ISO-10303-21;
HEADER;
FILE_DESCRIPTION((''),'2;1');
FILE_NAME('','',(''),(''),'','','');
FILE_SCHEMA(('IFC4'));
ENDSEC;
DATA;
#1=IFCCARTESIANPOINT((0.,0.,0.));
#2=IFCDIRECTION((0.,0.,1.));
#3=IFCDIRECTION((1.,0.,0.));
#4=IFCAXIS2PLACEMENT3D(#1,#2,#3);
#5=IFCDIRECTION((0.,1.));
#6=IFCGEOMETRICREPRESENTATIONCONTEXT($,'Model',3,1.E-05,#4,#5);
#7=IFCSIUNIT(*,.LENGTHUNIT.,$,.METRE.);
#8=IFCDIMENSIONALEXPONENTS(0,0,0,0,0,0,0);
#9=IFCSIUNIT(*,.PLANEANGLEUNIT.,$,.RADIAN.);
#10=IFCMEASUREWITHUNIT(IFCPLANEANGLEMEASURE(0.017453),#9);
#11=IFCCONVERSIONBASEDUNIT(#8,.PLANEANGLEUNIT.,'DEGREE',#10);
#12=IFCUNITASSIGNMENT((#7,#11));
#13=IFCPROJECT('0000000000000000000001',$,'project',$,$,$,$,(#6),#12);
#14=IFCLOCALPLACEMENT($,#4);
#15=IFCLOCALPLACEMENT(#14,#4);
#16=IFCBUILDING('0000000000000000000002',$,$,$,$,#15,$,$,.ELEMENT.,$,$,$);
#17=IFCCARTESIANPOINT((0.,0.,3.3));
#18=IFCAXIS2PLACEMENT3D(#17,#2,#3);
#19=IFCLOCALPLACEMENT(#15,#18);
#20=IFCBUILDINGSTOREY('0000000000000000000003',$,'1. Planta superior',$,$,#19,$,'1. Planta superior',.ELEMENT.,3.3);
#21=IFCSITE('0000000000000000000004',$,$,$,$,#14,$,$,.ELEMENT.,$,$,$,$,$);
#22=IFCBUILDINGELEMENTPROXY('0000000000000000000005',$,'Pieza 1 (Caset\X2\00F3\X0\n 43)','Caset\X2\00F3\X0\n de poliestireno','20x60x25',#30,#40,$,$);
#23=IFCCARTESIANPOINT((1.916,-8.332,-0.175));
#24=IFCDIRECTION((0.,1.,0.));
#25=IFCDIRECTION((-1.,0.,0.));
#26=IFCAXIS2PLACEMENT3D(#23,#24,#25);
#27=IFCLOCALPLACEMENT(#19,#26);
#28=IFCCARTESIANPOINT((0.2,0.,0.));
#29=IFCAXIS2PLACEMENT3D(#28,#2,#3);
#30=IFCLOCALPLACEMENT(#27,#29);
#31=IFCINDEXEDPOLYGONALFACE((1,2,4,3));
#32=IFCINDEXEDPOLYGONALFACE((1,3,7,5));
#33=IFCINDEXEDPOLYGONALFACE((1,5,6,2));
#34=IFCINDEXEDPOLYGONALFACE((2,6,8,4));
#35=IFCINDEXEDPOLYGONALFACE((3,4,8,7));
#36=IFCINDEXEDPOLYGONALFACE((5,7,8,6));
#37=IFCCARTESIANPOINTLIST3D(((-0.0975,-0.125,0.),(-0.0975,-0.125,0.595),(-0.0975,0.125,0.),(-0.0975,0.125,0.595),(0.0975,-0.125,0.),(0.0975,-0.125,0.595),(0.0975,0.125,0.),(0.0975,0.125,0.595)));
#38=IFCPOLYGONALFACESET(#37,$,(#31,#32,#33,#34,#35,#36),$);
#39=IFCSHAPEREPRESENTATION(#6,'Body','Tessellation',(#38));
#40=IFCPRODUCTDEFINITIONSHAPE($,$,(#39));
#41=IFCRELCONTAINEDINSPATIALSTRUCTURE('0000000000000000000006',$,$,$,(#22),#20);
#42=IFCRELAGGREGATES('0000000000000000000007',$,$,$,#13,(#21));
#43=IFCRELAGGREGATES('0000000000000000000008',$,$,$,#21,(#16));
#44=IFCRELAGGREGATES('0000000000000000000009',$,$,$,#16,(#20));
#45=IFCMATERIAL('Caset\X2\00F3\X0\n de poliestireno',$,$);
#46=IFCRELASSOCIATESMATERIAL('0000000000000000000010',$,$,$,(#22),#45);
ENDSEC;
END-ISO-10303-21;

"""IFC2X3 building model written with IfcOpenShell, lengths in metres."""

from ifc_helpers import new_model, entity, si_unit, converted_unit, direction, frame, origin_with_axes, origin_2d_with_axis, place, context, project, spatial, rectangle, extrude, source, transform, mapped, material, element, save


model = new_model("IFC2X3")

# Units and contexts
model_context = context("Model", 3, precision=1e-05, world=origin_with_axes(), true_north=direction((0.0, 1.0)))
ifc_project = project(units=[si_unit("LENGTHUNIT", "METRE"), converted_unit("PLANEANGLEUNIT", "DEGREE", entity("IfcPlaneAngleMeasure", 0.017453), si_unit("PLANEANGLEUNIT", "RADIAN"), dimensions=[0, 0, 0, 0, 0, 0, 0])], contexts=[model_context])

# Site, building, storey
site_placement = place(None, origin_with_axes())
site = spatial("IfcSite", under=ifc_project, at=site_placement, CompositionType="ELEMENT")
building_placement = place(site_placement, origin_with_axes())
building = spatial("IfcBuilding", under=site, at=building_placement, CompositionType="ELEMENT")
storey_placement = place(building_placement, frame((0.0, 0.0, 3.3), z_axis=(0.0, 0.0, 1.0), x_axis=(1.0, 0.0, 0.0)))
storey = spatial("IfcBuildingStorey", under=building, at=storey_placement, Name="1. Planta superior", LongName="1. Planta superior", CompositionType="ELEMENT", Elevation=3.3)

# Building element proxy
ifc_material = material(Name="Casetón de poliestireno")
shared_shape = source(origin_with_axes(), model_context, "Body", "SweptSolid", [
    extrude(rectangle(XDim=0.195, YDim=0.25, at=origin_2d_with_axis()), origin_with_axes(), (0.0, 0.0, 1.0), 0.595),
])
placement_1 = place(storey_placement, frame((1.916, -8.332, -0.175), z_axis=(0.0, 1.0, 0.0), x_axis=(-1.0, 0.0, 0.0)))
for number, where, z_axis, x_axis, name in (
    (1, (0.2, 0.0, 0.0), (0.0, 0.0, 1.0), (1.0, 0.0, 0.0), "Pieza 1 (Casetón 43)"),
):
    element("IfcBuildingElementProxy", number, at=place(placement_1, frame(where, z_axis=z_axis, x_axis=x_axis)), inside=storey, material=ifc_material, Name=name, Description="Casetón de poliestireno", ObjectType="20x60x25", context=model_context, shape_type="MappedRepresentation", body=[
        mapped(shared_shape, transform((0.0, 0.0, 0.0), x_axis=(1.0, 0.0, 0.0), y_axis=(0.0, 1.0, 0.0), z_axis=(0.0, 0.0, 1.0))),
    ])

save(model, "model.ifc")
